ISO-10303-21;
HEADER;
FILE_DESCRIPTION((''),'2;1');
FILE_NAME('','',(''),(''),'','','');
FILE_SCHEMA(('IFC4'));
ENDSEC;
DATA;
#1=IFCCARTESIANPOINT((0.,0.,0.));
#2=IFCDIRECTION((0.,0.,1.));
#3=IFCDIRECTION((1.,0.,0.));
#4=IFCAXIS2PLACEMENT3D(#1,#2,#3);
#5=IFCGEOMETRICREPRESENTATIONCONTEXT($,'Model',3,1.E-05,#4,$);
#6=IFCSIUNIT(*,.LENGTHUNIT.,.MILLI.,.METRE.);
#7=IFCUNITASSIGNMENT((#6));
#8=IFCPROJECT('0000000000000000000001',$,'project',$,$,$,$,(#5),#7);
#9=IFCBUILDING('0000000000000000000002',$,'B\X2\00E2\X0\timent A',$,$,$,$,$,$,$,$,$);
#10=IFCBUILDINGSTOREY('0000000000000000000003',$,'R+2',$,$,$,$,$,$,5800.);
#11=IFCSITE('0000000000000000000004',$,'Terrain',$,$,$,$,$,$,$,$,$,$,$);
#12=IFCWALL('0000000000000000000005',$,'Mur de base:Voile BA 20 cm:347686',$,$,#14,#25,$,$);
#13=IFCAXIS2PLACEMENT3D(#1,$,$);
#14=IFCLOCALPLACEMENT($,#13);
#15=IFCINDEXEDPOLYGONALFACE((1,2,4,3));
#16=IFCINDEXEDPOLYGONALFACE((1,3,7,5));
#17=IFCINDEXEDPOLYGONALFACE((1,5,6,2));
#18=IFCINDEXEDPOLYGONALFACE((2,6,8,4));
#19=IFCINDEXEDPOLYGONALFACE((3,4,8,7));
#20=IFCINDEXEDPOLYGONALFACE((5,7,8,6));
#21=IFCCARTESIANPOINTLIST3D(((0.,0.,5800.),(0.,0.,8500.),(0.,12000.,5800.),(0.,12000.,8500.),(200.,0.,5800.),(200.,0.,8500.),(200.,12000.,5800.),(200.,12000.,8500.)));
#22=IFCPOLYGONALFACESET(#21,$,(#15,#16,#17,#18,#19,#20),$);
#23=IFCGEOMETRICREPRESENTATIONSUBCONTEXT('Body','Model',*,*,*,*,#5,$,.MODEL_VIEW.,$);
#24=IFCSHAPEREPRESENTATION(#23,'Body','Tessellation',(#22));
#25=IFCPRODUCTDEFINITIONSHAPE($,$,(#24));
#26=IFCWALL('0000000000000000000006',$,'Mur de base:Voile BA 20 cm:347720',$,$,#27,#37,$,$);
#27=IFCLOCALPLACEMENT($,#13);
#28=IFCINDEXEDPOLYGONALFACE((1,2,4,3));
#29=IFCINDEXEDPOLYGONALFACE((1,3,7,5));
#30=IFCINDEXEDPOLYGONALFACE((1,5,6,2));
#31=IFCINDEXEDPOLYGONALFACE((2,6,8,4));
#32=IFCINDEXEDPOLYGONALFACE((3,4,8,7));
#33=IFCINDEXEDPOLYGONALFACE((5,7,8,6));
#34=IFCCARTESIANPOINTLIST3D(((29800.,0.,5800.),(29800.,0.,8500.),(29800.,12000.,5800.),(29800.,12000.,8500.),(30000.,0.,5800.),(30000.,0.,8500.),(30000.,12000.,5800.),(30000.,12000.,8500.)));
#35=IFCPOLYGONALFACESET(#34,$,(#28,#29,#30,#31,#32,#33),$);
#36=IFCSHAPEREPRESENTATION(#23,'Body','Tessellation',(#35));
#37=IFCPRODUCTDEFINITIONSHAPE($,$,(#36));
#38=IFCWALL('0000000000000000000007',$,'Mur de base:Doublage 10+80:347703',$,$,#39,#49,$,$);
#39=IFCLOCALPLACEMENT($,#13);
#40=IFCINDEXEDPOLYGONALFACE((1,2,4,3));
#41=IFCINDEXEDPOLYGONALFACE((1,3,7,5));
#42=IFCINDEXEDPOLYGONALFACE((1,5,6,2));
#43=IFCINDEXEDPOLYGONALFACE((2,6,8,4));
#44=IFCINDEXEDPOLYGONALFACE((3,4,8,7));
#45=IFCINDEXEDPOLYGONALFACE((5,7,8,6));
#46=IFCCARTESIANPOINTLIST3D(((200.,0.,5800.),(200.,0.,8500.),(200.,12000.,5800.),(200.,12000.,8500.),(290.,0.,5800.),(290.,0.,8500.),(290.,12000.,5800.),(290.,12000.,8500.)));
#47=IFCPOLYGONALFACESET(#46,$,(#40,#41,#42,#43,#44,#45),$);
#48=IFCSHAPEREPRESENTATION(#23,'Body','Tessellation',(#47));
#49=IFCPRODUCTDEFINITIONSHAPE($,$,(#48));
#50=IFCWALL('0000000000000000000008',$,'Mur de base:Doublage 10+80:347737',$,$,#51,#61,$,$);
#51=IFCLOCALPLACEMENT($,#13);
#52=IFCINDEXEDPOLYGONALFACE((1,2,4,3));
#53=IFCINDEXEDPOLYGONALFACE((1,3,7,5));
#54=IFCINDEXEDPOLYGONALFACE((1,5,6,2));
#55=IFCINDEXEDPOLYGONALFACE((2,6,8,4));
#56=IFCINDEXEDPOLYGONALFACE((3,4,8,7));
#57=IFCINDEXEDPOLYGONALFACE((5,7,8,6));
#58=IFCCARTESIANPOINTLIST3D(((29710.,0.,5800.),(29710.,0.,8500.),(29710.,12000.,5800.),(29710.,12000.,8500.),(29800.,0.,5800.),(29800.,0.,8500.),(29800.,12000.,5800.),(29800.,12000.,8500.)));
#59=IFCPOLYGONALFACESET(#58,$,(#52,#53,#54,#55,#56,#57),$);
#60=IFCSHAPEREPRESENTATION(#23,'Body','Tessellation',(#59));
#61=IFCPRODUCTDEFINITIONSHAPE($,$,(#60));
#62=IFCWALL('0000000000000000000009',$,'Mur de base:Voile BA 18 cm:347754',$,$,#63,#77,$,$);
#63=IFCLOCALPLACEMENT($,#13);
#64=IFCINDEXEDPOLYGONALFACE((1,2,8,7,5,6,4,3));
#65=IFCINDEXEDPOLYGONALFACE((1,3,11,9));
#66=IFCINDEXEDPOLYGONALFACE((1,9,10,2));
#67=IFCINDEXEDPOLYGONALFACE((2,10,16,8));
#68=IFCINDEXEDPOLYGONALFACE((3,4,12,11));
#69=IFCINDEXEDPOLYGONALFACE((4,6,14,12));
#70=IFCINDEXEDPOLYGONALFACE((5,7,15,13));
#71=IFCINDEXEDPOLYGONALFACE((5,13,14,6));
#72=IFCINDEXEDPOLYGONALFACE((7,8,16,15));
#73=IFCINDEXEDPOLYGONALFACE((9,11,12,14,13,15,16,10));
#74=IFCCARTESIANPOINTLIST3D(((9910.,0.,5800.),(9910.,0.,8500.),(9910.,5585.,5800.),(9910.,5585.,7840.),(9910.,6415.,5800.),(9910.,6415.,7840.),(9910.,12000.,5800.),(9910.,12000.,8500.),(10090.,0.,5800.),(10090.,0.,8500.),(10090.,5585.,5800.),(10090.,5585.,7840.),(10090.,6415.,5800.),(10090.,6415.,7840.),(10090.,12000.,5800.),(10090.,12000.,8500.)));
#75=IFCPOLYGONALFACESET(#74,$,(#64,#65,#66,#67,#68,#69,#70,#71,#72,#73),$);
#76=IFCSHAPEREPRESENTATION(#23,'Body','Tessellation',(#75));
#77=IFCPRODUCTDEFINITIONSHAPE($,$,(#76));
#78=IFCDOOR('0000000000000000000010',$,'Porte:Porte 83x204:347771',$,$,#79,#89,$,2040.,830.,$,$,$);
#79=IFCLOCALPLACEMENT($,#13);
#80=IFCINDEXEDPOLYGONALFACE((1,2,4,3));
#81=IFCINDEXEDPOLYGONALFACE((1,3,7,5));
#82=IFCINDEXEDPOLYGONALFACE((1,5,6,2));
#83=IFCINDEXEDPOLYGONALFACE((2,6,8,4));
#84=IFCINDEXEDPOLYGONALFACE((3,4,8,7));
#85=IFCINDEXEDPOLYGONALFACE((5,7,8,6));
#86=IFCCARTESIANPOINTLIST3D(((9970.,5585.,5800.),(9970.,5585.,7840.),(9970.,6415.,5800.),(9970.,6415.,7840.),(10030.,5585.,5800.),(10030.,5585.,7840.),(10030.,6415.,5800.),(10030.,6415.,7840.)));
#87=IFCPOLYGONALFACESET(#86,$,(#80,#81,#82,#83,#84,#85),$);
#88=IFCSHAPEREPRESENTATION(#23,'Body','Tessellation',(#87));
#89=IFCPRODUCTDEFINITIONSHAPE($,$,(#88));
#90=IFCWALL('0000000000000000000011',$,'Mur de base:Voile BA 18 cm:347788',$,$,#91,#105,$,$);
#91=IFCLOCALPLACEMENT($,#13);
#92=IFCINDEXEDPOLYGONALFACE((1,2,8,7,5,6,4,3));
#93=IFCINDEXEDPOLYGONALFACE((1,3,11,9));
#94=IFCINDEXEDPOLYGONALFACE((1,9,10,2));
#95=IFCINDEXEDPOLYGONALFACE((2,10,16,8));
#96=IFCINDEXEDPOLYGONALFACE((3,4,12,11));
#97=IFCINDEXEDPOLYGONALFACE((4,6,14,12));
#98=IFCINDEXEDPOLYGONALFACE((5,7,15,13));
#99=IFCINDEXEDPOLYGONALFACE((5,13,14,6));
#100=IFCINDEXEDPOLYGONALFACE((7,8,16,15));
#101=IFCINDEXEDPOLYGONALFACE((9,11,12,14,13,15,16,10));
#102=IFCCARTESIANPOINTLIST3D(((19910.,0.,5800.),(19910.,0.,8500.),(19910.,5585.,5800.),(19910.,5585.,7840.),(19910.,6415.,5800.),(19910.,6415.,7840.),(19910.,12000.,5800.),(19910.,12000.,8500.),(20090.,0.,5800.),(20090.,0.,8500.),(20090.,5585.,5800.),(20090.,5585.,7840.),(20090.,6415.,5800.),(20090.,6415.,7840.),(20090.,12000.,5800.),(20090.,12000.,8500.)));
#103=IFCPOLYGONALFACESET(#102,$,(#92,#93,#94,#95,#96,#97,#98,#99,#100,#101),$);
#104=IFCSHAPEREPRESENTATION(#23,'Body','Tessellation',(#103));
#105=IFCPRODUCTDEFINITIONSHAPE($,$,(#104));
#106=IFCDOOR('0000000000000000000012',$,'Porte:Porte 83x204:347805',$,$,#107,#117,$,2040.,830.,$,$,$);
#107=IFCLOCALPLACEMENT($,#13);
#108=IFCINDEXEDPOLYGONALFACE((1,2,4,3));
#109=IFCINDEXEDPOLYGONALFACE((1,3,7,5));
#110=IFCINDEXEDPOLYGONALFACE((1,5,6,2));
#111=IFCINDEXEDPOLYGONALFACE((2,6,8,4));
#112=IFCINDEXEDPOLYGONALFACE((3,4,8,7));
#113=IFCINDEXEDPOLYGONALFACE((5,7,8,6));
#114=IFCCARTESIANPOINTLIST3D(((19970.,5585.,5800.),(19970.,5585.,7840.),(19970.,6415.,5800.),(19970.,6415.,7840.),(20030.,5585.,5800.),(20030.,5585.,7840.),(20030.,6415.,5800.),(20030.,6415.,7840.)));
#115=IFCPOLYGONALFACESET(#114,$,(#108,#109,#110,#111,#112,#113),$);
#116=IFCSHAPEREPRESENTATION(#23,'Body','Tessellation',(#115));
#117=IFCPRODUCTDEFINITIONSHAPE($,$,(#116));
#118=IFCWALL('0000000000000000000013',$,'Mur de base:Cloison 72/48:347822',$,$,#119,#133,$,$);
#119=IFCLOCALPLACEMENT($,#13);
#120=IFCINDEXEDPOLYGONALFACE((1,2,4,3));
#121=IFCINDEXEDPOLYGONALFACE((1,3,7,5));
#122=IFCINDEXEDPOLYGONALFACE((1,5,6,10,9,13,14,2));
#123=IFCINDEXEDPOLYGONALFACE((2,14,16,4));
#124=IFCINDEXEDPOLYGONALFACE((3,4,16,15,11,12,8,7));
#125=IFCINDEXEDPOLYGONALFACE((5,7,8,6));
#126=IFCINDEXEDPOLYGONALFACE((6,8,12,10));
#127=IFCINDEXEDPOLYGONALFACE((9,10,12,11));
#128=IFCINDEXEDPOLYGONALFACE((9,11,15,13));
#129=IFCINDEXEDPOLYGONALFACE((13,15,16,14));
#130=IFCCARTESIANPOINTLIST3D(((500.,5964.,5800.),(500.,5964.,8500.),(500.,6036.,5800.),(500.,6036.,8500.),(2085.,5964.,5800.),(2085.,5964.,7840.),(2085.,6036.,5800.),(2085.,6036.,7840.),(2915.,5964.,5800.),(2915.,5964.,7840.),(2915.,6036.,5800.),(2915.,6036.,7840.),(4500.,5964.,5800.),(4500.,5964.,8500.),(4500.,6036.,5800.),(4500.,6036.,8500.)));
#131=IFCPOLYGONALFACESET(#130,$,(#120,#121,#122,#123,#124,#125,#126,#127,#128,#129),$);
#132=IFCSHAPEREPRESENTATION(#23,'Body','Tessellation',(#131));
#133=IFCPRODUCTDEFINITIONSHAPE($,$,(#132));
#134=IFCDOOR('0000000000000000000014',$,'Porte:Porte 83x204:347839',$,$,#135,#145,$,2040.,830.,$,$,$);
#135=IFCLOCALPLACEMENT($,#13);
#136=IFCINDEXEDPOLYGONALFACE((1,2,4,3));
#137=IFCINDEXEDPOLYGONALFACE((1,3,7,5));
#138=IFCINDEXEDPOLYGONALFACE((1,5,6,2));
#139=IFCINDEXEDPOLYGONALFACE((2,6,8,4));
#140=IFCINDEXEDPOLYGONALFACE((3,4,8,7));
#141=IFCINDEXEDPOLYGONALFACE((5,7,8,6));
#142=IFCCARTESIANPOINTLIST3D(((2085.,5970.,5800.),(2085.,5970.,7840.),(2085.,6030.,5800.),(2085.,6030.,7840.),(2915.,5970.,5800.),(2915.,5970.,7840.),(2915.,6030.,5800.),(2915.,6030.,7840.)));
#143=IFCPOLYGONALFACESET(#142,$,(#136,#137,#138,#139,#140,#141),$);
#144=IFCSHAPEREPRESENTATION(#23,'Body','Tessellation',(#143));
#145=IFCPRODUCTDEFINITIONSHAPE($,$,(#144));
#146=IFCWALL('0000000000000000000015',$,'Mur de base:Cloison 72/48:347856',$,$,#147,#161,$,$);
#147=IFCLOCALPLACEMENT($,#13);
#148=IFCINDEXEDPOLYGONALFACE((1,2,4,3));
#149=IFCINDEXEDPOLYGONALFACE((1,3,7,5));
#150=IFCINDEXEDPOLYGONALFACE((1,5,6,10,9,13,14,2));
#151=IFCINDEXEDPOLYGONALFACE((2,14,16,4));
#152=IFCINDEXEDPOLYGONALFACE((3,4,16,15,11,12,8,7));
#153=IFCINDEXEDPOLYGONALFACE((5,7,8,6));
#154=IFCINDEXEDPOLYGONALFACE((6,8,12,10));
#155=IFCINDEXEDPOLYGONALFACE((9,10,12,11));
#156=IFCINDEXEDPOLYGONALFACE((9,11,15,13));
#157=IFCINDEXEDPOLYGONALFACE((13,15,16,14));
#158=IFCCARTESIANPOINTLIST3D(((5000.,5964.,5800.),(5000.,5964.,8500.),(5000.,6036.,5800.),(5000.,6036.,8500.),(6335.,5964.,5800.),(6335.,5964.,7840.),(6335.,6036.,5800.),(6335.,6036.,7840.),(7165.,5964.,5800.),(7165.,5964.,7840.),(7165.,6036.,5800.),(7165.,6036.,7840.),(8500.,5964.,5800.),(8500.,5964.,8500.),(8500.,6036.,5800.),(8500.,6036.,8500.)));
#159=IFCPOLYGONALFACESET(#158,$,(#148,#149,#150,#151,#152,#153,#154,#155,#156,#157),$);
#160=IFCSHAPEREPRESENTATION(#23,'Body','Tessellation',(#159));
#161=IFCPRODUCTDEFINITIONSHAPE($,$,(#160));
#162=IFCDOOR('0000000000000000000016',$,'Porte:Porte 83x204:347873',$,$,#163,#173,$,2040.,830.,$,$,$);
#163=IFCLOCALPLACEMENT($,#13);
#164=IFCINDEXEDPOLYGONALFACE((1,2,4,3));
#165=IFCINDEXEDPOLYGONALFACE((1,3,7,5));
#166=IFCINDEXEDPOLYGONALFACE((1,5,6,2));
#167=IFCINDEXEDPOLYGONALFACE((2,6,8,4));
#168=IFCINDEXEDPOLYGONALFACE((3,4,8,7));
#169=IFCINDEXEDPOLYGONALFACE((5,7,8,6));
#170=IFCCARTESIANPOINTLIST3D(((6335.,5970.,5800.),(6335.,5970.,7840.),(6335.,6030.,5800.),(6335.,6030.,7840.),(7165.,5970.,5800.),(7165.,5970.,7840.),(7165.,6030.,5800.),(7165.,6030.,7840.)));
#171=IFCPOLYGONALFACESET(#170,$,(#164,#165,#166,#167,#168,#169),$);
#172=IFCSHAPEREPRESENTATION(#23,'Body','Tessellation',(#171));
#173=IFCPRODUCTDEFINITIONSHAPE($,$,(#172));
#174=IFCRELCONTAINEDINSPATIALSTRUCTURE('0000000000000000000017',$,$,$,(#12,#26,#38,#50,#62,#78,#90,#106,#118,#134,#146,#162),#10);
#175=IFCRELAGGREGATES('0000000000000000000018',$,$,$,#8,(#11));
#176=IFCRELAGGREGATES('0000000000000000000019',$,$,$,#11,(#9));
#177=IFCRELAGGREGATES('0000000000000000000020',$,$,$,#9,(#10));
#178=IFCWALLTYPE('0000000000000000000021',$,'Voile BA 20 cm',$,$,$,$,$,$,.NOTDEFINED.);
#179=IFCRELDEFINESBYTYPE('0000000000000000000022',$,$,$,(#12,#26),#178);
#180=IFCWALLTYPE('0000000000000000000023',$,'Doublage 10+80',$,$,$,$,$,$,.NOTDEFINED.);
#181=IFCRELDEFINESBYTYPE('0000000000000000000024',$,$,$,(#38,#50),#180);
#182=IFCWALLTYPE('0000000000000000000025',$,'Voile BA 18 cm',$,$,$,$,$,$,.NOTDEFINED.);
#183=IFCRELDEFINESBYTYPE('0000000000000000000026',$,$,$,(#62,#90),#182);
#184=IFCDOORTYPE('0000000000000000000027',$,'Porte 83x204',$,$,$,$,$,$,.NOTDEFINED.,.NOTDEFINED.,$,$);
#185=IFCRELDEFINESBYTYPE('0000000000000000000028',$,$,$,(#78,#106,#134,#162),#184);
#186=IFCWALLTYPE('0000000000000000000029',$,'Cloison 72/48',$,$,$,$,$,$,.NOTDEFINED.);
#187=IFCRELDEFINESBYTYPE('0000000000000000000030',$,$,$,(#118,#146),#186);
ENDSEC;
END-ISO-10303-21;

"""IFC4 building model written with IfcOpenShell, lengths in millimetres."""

from ifc_helpers import new_model, si_unit, frame, frame_2d, origin_with_axes, place, context, subcontext, project, spatial, rectangle, extrude, type_object, element, fill, save


model = new_model("IFC4")

# Units and contexts
model_context = context("Model", 3, precision=1e-05, world=origin_with_axes())
body_context = subcontext(model_context, "Body", "Model", "MODEL_VIEW")
ifc_project = project(units=[si_unit("LENGTHUNIT", "METRE", prefix="MILLI")], contexts=[model_context])

# Site, building, storey
site = spatial("IfcSite", under=ifc_project, Name="Terrain")
building = spatial("IfcBuilding", under=site, Name="Bâtiment A")
storey = spatial("IfcBuildingStorey", under=building, Name="R+2", Elevation=5800.0)

# Walls
wall_type_1 = type_object("IfcWallType", Name="Voile BA 20 cm", PredefinedType="NOTDEFINED")
wall_1_placement = place(None, origin_with_axes())
element("IfcWall", 1, at=wall_1_placement, inside=storey, type_object=wall_type_1, Name="Mur de base:Voile BA 20 cm:347686", context=body_context, shape_type="SweptSolid", body=[
    extrude(rectangle(XDim=200.0, YDim=12000.0, at=frame_2d((100.0, 6000.0))), frame((0.0, 0.0, 5800.0), z_axis=(0.0, 0.0, 1.0), x_axis=(1.0, 0.0, 0.0)), (0.0, 0.0, 1.0), 2700.0),
])
wall_2_placement = place(None, origin_with_axes())
element("IfcWall", 2, at=wall_2_placement, inside=storey, type_object=wall_type_1, Name="Mur de base:Voile BA 20 cm:347720", context=body_context, shape_type="SweptSolid", body=[
    extrude(rectangle(XDim=200.0, YDim=12000.0, at=frame_2d((29900.0, 6000.0))), frame((0.0, 0.0, 5800.0), z_axis=(0.0, 0.0, 1.0), x_axis=(1.0, 0.0, 0.0)), (0.0, 0.0, 1.0), 2700.0),
])
wall_type_2 = type_object("IfcWallType", Name="Doublage 10+80", PredefinedType="NOTDEFINED")
wall_3_placement = place(None, origin_with_axes())
element("IfcWall", 3, at=wall_3_placement, inside=storey, type_object=wall_type_2, Name="Mur de base:Doublage 10+80:347703", context=body_context, shape_type="SweptSolid", body=[
    extrude(rectangle(XDim=90.0, YDim=12000.0, at=frame_2d((245.0, 6000.0))), frame((0.0, 0.0, 5800.0), z_axis=(0.0, 0.0, 1.0), x_axis=(1.0, 0.0, 0.0)), (0.0, 0.0, 1.0), 2700.0),
])
wall_4_placement = place(None, origin_with_axes())
element("IfcWall", 4, at=wall_4_placement, inside=storey, type_object=wall_type_2, Name="Mur de base:Doublage 10+80:347737", context=body_context, shape_type="SweptSolid", body=[
    extrude(rectangle(XDim=90.0, YDim=12000.0, at=frame_2d((29755.0, 6000.0))), frame((0.0, 0.0, 5800.0), z_axis=(0.0, 0.0, 1.0), x_axis=(1.0, 0.0, 0.0)), (0.0, 0.0, 1.0), 2700.0),
])

# Walls, openings, doors
wall_type_3 = type_object("IfcWallType", Name="Voile BA 18 cm", PredefinedType="NOTDEFINED")
wall_5_placement = place(None, origin_with_axes())
wall_5 = element("IfcWall", 5, at=wall_5_placement, inside=storey, type_object=wall_type_3, Name="Mur de base:Voile BA 18 cm:347754", context=body_context, shape_type="SweptSolid", body=[
    extrude(rectangle(XDim=180.0, YDim=12000.0, at=frame_2d((10000.0, 6000.0))), frame((0.0, 0.0, 5800.0), z_axis=(0.0, 0.0, 1.0), x_axis=(1.0, 0.0, 0.0)), (0.0, 0.0, 1.0), 2700.0),
])
opening_1_placement = place(None, origin_with_axes())
opening_1 = element("IfcOpeningElement", 6, at=opening_1_placement, cuts=wall_5, context=body_context, shape_type="SweptSolid", body=[
    extrude(rectangle(XDim=300.0, YDim=830.0, at=frame_2d((10000.0, 6000.0))), frame((0.0, 0.0, 5800.0), z_axis=(0.0, 0.0, 1.0), x_axis=(1.0, 0.0, 0.0)), (0.0, 0.0, 1.0), 2040.0),
])
door_type = type_object("IfcDoorType", Name="Porte 83x204", OperationType="NOTDEFINED", PredefinedType="NOTDEFINED")
door_1_placement = place(None, origin_with_axes())
door_1 = element("IfcDoor", 7, at=door_1_placement, inside=storey, type_object=door_type, Name="Porte:Porte 83x204:347771", OverallHeight=2040.0, OverallWidth=830.0, context=body_context, shape_type="SweptSolid", body=[
    extrude(rectangle(XDim=60.0, YDim=830.0, at=frame_2d((10000.0, 6000.0))), frame((0.0, 0.0, 5800.0), z_axis=(0.0, 0.0, 1.0), x_axis=(1.0, 0.0, 0.0)), (0.0, 0.0, 1.0), 2040.0),
])
fill(opening_1, door_1)
wall_6_placement = place(None, origin_with_axes())
wall_6 = element("IfcWall", 8, at=wall_6_placement, inside=storey, type_object=wall_type_3, Name="Mur de base:Voile BA 18 cm:347788", context=body_context, shape_type="SweptSolid", body=[
    extrude(rectangle(XDim=180.0, YDim=12000.0, at=frame_2d((20000.0, 6000.0))), frame((0.0, 0.0, 5800.0), z_axis=(0.0, 0.0, 1.0), x_axis=(1.0, 0.0, 0.0)), (0.0, 0.0, 1.0), 2700.0),
])
opening_2_placement = place(None, origin_with_axes())
opening_2 = element("IfcOpeningElement", 9, at=opening_2_placement, cuts=wall_6, context=body_context, shape_type="SweptSolid", body=[
    extrude(rectangle(XDim=300.0, YDim=830.0, at=frame_2d((20000.0, 6000.0))), frame((0.0, 0.0, 5800.0), z_axis=(0.0, 0.0, 1.0), x_axis=(1.0, 0.0, 0.0)), (0.0, 0.0, 1.0), 2040.0),
])
door_2_placement = place(None, origin_with_axes())
door_2 = element("IfcDoor", 10, at=door_2_placement, inside=storey, type_object=door_type, Name="Porte:Porte 83x204:347805", OverallHeight=2040.0, OverallWidth=830.0, context=body_context, shape_type="SweptSolid", body=[
    extrude(rectangle(XDim=60.0, YDim=830.0, at=frame_2d((20000.0, 6000.0))), frame((0.0, 0.0, 5800.0), z_axis=(0.0, 0.0, 1.0), x_axis=(1.0, 0.0, 0.0)), (0.0, 0.0, 1.0), 2040.0),
])
fill(opening_2, door_2)
wall_type_4 = type_object("IfcWallType", Name="Cloison 72/48", PredefinedType="NOTDEFINED")
wall_7_placement = place(None, origin_with_axes())
wall_7 = element("IfcWall", 11, at=wall_7_placement, inside=storey, type_object=wall_type_4, Name="Mur de base:Cloison 72/48:347822", context=body_context, shape_type="SweptSolid", body=[
    extrude(rectangle(XDim=4000.0, YDim=72.0, at=frame_2d((2500.0, 6000.0))), frame((0.0, 0.0, 5800.0), z_axis=(0.0, 0.0, 1.0), x_axis=(1.0, 0.0, 0.0)), (0.0, 0.0, 1.0), 2700.0),
])
opening_3_placement = place(None, origin_with_axes())
opening_3 = element("IfcOpeningElement", 12, at=opening_3_placement, cuts=wall_7, context=body_context, shape_type="SweptSolid", body=[
    extrude(rectangle(XDim=830.0, YDim=192.0, at=frame_2d((2500.0, 6000.0))), frame((0.0, 0.0, 5800.0), z_axis=(0.0, 0.0, 1.0), x_axis=(1.0, 0.0, 0.0)), (0.0, 0.0, 1.0), 2040.0),
])
door_3_placement = place(None, origin_with_axes())
door_3 = element("IfcDoor", 13, at=door_3_placement, inside=storey, type_object=door_type, Name="Porte:Porte 83x204:347839", OverallHeight=2040.0, OverallWidth=830.0, context=body_context, shape_type="SweptSolid", body=[
    extrude(rectangle(XDim=830.0, YDim=60.0, at=frame_2d((2500.0, 6000.0))), frame((0.0, 0.0, 5800.0), z_axis=(0.0, 0.0, 1.0), x_axis=(1.0, 0.0, 0.0)), (0.0, 0.0, 1.0), 2040.0),
])
fill(opening_3, door_3)
wall_8_placement = place(None, origin_with_axes())
wall_8 = element("IfcWall", 14, at=wall_8_placement, inside=storey, type_object=wall_type_4, Name="Mur de base:Cloison 72/48:347856", context=body_context, shape_type="SweptSolid", body=[
    extrude(rectangle(XDim=3500.0, YDim=72.0, at=frame_2d((6750.0, 6000.0))), frame((0.0, 0.0, 5800.0), z_axis=(0.0, 0.0, 1.0), x_axis=(1.0, 0.0, 0.0)), (0.0, 0.0, 1.0), 2700.0),
])
opening_4_placement = place(None, origin_with_axes())
opening_4 = element("IfcOpeningElement", 15, at=opening_4_placement, cuts=wall_8, context=body_context, shape_type="SweptSolid", body=[
    extrude(rectangle(XDim=830.0, YDim=192.0, at=frame_2d((6750.0, 6000.0))), frame((0.0, 0.0, 5800.0), z_axis=(0.0, 0.0, 1.0), x_axis=(1.0, 0.0, 0.0)), (0.0, 0.0, 1.0), 2040.0),
])
door_4_placement = place(None, origin_with_axes())
door_4 = element("IfcDoor", 16, at=door_4_placement, inside=storey, type_object=door_type, Name="Porte:Porte 83x204:347873", OverallHeight=2040.0, OverallWidth=830.0, context=body_context, shape_type="SweptSolid", body=[
    extrude(rectangle(XDim=830.0, YDim=60.0, at=frame_2d((6750.0, 6000.0))), frame((0.0, 0.0, 5800.0), z_axis=(0.0, 0.0, 1.0), x_axis=(1.0, 0.0, 0.0)), (0.0, 0.0, 1.0), 2040.0),
])
fill(opening_4, door_4)

save(model, "model.ifc")
